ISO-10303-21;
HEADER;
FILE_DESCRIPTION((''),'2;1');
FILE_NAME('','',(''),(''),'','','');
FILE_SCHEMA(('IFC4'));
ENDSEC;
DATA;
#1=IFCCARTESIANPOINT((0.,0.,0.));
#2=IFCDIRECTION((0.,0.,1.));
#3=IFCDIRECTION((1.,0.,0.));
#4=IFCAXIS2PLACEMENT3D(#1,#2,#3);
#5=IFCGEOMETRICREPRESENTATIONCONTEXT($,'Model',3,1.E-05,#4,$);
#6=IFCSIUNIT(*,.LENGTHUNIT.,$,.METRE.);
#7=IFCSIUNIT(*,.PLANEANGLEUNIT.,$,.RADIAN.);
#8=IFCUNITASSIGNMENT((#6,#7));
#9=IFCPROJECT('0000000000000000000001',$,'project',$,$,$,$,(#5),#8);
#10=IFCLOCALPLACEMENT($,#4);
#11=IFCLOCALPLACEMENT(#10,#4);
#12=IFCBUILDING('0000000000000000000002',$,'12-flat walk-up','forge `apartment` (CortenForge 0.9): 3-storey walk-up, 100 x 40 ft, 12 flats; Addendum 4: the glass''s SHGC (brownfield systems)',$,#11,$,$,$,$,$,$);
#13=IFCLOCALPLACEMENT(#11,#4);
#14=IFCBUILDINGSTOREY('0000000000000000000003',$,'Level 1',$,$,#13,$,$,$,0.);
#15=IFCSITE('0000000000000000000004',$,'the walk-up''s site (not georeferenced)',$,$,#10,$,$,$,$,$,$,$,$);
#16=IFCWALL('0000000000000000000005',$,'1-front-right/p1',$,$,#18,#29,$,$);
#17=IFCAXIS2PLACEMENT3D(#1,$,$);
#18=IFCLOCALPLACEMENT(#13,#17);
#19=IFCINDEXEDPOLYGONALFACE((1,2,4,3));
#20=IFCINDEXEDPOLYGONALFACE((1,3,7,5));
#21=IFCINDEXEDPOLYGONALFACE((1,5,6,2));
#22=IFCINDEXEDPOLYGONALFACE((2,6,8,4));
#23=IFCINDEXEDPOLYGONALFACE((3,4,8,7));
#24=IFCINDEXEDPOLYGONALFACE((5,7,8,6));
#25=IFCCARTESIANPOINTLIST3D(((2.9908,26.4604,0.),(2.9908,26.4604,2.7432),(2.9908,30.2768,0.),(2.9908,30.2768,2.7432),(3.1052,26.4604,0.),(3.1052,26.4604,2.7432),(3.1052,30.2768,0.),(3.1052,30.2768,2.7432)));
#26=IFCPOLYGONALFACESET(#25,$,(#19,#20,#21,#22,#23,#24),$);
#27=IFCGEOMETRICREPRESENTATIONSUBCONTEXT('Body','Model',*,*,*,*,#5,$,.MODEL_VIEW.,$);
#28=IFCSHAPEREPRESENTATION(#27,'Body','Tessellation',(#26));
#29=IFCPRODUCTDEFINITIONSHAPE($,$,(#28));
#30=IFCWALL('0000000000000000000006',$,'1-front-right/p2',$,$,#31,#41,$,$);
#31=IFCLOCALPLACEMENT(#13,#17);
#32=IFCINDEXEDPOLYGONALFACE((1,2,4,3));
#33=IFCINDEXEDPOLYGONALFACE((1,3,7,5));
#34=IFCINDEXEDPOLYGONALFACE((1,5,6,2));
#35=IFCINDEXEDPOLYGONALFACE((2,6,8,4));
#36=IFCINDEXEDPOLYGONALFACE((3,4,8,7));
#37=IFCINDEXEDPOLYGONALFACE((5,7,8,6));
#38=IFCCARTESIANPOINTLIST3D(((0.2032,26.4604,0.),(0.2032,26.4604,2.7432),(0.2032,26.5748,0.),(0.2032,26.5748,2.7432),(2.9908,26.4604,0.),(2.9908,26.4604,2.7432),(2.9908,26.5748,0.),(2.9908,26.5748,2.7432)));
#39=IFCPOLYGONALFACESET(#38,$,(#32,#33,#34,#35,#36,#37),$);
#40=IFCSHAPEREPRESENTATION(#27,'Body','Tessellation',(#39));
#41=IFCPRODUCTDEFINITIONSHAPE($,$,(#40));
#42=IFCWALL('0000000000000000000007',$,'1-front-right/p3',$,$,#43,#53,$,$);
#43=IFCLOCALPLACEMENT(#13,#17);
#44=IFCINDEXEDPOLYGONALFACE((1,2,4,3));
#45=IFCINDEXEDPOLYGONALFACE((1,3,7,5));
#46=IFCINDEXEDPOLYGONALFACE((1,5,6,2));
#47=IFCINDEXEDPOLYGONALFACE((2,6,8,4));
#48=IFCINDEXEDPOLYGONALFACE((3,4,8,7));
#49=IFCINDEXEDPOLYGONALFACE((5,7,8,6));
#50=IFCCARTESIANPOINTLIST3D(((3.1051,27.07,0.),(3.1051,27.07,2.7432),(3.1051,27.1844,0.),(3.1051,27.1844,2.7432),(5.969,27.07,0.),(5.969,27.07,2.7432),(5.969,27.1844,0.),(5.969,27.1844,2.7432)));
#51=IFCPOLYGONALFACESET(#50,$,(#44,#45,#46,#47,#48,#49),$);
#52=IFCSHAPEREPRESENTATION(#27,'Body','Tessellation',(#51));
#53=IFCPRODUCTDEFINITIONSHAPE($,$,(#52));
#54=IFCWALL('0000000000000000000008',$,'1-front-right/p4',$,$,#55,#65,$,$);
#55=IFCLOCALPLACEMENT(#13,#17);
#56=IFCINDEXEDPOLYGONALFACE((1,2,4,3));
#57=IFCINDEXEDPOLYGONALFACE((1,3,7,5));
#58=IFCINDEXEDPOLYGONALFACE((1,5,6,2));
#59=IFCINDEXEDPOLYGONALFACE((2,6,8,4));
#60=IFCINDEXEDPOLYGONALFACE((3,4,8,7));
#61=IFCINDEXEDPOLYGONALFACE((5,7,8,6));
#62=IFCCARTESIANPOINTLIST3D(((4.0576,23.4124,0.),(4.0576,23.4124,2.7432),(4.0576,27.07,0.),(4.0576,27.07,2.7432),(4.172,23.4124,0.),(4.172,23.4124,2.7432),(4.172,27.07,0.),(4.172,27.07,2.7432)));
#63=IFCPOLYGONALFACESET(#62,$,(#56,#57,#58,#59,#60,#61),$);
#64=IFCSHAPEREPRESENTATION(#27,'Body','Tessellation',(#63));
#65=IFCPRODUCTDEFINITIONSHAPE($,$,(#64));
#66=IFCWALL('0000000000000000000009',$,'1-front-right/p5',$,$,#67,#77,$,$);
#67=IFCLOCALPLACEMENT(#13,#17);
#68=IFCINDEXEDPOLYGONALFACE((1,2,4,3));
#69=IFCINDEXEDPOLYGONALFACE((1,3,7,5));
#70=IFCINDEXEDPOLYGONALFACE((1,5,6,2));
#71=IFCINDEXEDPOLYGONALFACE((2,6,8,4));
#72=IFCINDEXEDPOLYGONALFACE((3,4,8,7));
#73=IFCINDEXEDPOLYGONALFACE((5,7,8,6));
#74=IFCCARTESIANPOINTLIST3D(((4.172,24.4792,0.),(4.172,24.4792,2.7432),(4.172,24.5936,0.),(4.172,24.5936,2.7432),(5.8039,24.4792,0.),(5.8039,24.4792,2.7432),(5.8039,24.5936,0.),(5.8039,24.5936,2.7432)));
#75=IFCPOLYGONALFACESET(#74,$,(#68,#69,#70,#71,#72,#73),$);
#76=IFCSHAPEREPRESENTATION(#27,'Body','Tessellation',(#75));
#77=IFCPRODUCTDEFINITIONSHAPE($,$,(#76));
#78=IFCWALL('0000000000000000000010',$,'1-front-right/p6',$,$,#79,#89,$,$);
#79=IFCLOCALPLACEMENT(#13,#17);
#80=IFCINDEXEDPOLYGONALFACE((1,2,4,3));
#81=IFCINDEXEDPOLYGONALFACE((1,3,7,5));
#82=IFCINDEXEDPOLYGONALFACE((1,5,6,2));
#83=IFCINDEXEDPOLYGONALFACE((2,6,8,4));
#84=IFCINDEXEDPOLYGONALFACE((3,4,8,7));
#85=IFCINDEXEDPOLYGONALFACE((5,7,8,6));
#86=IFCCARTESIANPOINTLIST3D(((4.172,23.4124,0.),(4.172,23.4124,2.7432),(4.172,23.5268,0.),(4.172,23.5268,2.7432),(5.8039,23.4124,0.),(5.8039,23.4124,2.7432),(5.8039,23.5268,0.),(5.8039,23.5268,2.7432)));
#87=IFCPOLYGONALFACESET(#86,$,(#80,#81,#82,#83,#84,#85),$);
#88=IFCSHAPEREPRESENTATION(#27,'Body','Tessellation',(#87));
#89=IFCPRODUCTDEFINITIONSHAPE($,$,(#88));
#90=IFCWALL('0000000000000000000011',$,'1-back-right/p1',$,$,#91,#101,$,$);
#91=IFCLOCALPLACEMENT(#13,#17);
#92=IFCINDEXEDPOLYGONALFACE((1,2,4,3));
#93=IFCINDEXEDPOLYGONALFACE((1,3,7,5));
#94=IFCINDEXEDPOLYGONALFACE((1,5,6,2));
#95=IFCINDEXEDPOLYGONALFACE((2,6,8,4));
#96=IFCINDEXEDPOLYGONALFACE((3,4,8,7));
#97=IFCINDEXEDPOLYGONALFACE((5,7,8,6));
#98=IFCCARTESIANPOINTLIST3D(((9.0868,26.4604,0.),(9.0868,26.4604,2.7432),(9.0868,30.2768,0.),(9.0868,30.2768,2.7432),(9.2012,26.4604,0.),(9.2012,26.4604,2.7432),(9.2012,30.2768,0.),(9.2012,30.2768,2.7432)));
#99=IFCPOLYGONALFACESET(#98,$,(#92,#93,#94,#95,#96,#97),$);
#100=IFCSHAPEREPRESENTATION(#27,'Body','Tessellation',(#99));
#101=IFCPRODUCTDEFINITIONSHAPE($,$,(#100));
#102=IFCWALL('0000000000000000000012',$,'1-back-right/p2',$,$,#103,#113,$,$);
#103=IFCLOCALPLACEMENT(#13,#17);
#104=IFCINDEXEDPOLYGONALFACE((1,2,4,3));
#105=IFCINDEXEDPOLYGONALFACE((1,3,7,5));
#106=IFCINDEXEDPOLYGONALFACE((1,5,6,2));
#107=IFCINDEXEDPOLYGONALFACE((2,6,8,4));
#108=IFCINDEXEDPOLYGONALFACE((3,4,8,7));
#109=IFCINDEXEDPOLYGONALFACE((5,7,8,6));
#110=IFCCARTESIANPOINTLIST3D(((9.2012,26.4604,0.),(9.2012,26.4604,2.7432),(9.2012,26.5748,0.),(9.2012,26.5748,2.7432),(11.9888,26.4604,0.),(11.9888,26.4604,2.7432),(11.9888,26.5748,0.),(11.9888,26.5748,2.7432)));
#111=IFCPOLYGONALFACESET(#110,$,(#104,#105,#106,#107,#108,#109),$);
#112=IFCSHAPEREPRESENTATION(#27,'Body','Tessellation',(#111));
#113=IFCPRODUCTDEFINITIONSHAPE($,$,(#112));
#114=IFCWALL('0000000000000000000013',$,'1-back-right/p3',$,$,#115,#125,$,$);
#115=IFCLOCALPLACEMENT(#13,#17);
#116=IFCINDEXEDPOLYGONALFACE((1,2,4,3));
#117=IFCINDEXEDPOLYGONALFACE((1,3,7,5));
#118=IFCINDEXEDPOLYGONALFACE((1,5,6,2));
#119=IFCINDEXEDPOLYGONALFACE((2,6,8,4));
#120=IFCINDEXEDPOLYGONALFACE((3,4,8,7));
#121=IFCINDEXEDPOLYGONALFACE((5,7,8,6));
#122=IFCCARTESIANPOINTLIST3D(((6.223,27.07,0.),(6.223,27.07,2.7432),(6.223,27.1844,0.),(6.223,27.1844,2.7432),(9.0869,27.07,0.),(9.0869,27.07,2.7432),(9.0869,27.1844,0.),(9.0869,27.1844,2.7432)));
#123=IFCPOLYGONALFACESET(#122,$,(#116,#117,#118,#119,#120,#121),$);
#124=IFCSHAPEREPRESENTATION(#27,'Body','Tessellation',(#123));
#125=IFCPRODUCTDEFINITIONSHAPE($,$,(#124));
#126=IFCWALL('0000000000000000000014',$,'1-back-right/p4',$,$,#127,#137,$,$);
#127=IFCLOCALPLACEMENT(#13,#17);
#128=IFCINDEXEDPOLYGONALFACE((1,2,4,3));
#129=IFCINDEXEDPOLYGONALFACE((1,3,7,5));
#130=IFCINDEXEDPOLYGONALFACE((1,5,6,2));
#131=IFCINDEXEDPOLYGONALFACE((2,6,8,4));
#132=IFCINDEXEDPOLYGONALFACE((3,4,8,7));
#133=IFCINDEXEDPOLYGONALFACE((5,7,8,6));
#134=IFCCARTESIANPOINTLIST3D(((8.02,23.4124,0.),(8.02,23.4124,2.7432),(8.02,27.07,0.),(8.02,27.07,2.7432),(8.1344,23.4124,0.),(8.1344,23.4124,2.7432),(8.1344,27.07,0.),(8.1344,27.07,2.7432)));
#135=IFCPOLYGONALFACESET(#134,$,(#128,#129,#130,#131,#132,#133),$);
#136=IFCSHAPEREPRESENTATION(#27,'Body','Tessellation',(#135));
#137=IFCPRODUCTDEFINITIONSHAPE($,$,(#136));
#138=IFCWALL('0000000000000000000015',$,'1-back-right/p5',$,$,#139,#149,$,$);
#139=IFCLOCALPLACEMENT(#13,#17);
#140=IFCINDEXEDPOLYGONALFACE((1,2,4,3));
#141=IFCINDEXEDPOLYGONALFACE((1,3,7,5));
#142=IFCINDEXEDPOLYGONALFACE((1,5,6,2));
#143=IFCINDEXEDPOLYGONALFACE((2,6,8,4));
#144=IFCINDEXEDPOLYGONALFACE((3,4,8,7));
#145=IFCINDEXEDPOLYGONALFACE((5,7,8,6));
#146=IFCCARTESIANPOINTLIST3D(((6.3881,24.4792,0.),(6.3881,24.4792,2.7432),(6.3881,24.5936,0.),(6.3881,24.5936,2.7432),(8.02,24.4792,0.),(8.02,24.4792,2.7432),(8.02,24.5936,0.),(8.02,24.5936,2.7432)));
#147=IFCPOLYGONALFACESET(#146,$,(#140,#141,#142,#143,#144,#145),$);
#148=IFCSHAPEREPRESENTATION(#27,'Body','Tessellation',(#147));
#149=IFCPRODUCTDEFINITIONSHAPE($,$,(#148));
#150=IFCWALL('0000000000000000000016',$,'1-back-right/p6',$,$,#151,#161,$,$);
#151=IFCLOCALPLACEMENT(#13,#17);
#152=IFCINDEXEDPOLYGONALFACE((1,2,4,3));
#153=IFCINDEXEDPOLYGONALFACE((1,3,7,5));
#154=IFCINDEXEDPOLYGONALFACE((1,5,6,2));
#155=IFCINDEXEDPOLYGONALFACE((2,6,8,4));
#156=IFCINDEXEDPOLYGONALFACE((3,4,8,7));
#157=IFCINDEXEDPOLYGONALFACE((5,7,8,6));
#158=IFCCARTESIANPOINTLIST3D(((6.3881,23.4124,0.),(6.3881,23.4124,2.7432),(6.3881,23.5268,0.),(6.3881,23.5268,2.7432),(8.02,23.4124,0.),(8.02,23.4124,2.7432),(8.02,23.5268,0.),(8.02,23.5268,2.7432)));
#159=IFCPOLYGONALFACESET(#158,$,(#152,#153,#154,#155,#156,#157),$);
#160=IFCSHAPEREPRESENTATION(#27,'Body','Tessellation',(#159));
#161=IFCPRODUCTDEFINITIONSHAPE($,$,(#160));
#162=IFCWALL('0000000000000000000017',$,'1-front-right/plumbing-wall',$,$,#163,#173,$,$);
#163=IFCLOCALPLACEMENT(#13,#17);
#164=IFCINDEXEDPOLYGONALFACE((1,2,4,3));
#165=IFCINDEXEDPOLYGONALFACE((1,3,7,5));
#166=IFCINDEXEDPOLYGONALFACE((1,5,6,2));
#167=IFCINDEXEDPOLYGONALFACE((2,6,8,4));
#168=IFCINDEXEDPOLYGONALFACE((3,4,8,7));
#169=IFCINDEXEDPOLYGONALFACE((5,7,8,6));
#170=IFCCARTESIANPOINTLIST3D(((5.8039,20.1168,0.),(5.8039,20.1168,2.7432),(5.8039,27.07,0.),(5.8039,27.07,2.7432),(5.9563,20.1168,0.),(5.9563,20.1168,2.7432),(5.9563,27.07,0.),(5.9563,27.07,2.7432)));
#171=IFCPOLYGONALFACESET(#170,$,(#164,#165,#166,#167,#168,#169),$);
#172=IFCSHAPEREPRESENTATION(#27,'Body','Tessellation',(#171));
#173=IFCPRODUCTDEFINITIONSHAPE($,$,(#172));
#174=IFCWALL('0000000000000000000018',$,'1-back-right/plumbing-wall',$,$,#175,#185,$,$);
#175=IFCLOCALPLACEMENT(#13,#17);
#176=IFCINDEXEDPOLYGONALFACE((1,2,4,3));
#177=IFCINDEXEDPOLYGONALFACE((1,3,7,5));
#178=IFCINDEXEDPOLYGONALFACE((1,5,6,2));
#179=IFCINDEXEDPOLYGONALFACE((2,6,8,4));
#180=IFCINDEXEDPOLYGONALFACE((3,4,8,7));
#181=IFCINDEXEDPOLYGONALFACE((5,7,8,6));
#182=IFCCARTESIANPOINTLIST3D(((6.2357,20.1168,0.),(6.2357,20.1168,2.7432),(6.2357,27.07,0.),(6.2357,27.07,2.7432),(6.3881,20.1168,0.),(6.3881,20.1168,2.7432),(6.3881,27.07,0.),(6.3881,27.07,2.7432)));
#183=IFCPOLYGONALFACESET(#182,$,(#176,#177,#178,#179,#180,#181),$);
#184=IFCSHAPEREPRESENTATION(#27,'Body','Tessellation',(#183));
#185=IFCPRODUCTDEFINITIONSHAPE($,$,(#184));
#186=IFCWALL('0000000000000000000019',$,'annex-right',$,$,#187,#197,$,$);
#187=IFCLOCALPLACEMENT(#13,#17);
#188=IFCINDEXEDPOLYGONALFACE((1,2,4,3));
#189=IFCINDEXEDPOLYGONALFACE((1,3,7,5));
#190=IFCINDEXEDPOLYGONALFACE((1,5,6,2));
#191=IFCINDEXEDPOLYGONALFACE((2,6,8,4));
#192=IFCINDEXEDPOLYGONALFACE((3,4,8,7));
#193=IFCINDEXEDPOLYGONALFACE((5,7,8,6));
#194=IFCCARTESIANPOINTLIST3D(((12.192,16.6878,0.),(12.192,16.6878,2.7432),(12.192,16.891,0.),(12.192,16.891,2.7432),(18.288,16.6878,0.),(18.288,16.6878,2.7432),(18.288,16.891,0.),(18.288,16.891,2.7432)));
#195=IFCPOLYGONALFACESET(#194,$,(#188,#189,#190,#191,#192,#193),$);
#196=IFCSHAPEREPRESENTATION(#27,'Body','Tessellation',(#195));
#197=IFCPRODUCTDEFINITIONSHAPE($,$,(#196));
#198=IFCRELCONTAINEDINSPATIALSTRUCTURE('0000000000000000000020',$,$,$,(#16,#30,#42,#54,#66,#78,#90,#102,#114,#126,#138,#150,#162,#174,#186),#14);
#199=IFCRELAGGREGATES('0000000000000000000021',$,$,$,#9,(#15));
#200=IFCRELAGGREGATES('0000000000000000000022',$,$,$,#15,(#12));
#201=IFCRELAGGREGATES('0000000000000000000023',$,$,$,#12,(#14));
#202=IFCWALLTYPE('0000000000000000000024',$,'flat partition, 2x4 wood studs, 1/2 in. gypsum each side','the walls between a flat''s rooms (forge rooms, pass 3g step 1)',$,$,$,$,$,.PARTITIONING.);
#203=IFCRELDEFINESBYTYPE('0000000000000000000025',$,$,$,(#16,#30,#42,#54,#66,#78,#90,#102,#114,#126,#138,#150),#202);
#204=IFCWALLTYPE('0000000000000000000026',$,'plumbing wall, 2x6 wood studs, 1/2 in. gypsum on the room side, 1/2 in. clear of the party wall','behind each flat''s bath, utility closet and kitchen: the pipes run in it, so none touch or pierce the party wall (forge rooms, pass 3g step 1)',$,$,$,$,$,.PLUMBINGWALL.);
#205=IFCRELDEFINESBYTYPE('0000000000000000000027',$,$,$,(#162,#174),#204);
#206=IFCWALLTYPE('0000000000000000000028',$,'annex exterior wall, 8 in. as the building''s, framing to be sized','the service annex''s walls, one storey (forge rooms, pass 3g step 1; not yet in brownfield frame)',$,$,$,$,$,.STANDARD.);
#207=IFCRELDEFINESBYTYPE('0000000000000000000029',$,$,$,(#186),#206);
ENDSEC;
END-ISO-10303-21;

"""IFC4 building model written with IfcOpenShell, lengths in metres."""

from ifc_helpers import new_model, si_unit, frame, frame_2d, origin, origin_with_axes, place, context, subcontext, project, spatial, rectangle, extrude, type_object, element, save


model = new_model("IFC4")

# Units and contexts
model_context = context("Model", 3, precision=1e-05, world=origin_with_axes())
body_context = subcontext(model_context, "Body", "Model", "MODEL_VIEW")
ifc_project = project(units=[si_unit("LENGTHUNIT", "METRE"), si_unit("PLANEANGLEUNIT", "RADIAN")], contexts=[model_context])

# Site, building, storey
site_placement = place(None, origin_with_axes())
site = spatial("IfcSite", under=ifc_project, at=site_placement, Name="the walk-up's site (not georeferenced)")
building_placement = place(site_placement, origin_with_axes())
building = spatial("IfcBuilding", under=site, at=building_placement, Name="12-flat walk-up", Description="forge `apartment` (CortenForge 0.9): 3-storey walk-up, 100 x 40 ft, 12 flats; Addendum 4: the glass's SHGC (brownfield systems)")
storey_placement = place(building_placement, origin_with_axes())
storey = spatial("IfcBuildingStorey", under=building, at=storey_placement, Name="Level 1", Elevation=0.0)

# Walls
wall_type_1 = type_object("IfcWallType", Name="flat partition, 2x4 wood studs, 1/2 in. gypsum each side", Description="the walls between a flat's rooms (forge rooms, pass 3g step 1)", PredefinedType="PARTITIONING")
wall_1_placement = place(storey_placement, frame((2.9909, 26.4605, 0.0), z_axis=(0.0, 0.0, 1.0), x_axis=(1.0, 0.0, 0.0)))
element("IfcWall", 1, at=wall_1_placement, inside=storey, type_object=wall_type_1, Name="1-front-right/p1", context=body_context, shape_type="SweptSolid", body=[
    extrude(rectangle(XDim=0.1143, YDim=3.8163, at=frame_2d((0.0572, 1.9082))), origin(), (0.0, 0.0, 1.0), 2.7432),
])
wall_2_placement = place(storey_placement, frame((0.2032, 26.4605, 0.0), z_axis=(0.0, 0.0, 1.0), x_axis=(1.0, 0.0, 0.0)))
element("IfcWall", 2, at=wall_2_placement, inside=storey, type_object=wall_type_1, Name="1-front-right/p2", context=body_context, shape_type="SweptSolid", body=[
    extrude(rectangle(XDim=2.7877, YDim=0.1143, at=frame_2d((1.3938, 0.0572))), origin(), (0.0, 0.0, 1.0), 2.7432),
])
wall_3_placement = place(storey_placement, frame((3.1051, 27.07, 0.0), z_axis=(0.0, 0.0, 1.0), x_axis=(1.0, 0.0, 0.0)))
element("IfcWall", 3, at=wall_3_placement, inside=storey, type_object=wall_type_1, Name="1-front-right/p3", context=body_context, shape_type="SweptSolid", body=[
    extrude(rectangle(XDim=2.8639, YDim=0.1143, at=frame_2d((1.4319, 0.0572))), origin(), (0.0, 0.0, 1.0), 2.7432),
])
wall_4_placement = place(storey_placement, frame((4.0576, 23.4124, 0.0), z_axis=(0.0, 0.0, 1.0), x_axis=(1.0, 0.0, 0.0)))
element("IfcWall", 4, at=wall_4_placement, inside=storey, type_object=wall_type_1, Name="1-front-right/p4", context=body_context, shape_type="SweptSolid", body=[
    extrude(rectangle(XDim=0.1143, YDim=3.6576, at=frame_2d((0.0572, 1.8288))), origin(), (0.0, 0.0, 1.0), 2.7432),
])
for number, where, z_axis, x_axis, name in (
    (5, (4.1719, 24.4793, 0.0), (0.0, 0.0, 1.0), (1.0, 0.0, 0.0), "1-front-right/p5"),
    (6, (4.1719, 23.4124, 0.0), (0.0, 0.0, 1.0), (1.0, 0.0, 0.0), "1-front-right/p6"),
):
    element("IfcWall", number, at=place(storey_placement, frame(where, z_axis=z_axis, x_axis=x_axis)), inside=storey, type_object=wall_type_1, Name=name, context=body_context, shape_type="SweptSolid", body=[
        extrude(rectangle(XDim=1.6319, YDim=0.1143, at=frame_2d((0.816, 0.0572))), origin(), (0.0, 0.0, 1.0), 2.7432),
    ])
wall_5_placement = place(storey_placement, frame((9.0869, 26.4605, 0.0), z_axis=(0.0, 0.0, 1.0), x_axis=(1.0, 0.0, 0.0)))
element("IfcWall", 7, at=wall_5_placement, inside=storey, type_object=wall_type_1, Name="1-back-right/p1", context=body_context, shape_type="SweptSolid", body=[
    extrude(rectangle(XDim=0.1143, YDim=3.8163, at=frame_2d((0.0572, 1.9082))), origin(), (0.0, 0.0, 1.0), 2.7432),
])
wall_6_placement = place(storey_placement, frame((9.2012, 26.4605, 0.0), z_axis=(0.0, 0.0, 1.0), x_axis=(1.0, 0.0, 0.0)))
element("IfcWall", 8, at=wall_6_placement, inside=storey, type_object=wall_type_1, Name="1-back-right/p2", context=body_context, shape_type="SweptSolid", body=[
    extrude(rectangle(XDim=2.7876, YDim=0.1143, at=frame_2d((1.3938, 0.0572))), origin(), (0.0, 0.0, 1.0), 2.7432),
])
wall_7_placement = place(storey_placement, frame((6.223, 27.07, 0.0), z_axis=(0.0, 0.0, 1.0), x_axis=(1.0, 0.0, 0.0)))
element("IfcWall", 9, at=wall_7_placement, inside=storey, type_object=wall_type_1, Name="1-back-right/p3", context=body_context, shape_type="SweptSolid", body=[
    extrude(rectangle(XDim=2.8639, YDim=0.1143, at=frame_2d((1.4319, 0.0572))), origin(), (0.0, 0.0, 1.0), 2.7432),
])
wall_8_placement = place(storey_placement, frame((8.02, 23.4124, 0.0), z_axis=(0.0, 0.0, 1.0), x_axis=(1.0, 0.0, 0.0)))
element("IfcWall", 10, at=wall_8_placement, inside=storey, type_object=wall_type_1, Name="1-back-right/p4", context=body_context, shape_type="SweptSolid", body=[
    extrude(rectangle(XDim=0.1143, YDim=3.6576, at=frame_2d((0.0572, 1.8288))), origin(), (0.0, 0.0, 1.0), 2.7432),
])
for number, where, z_axis, x_axis, name in (
    (11, (6.3881, 24.4793, 0.0), (0.0, 0.0, 1.0), (1.0, 0.0, 0.0), "1-back-right/p5"),
    (12, (6.3881, 23.4124, 0.0), (0.0, 0.0, 1.0), (1.0, 0.0, 0.0), "1-back-right/p6"),
):
    element("IfcWall", number, at=place(storey_placement, frame(where, z_axis=z_axis, x_axis=x_axis)), inside=storey, type_object=wall_type_1, Name=name, context=body_context, shape_type="SweptSolid", body=[
        extrude(rectangle(XDim=1.6319, YDim=0.1143, at=frame_2d((0.816, 0.0572))), origin(), (0.0, 0.0, 1.0), 2.7432),
    ])
wall_type_2 = type_object("IfcWallType", Name="plumbing wall, 2x6 wood studs, 1/2 in. gypsum on the room side, 1/2 in. clear of the party wall", Description="behind each flat's bath, utility closet and kitchen: the pipes run in it, so none touch or pierce the party wall (forge rooms, pass 3g step 1)", PredefinedType="PLUMBINGWALL")
for number, where, z_axis, x_axis, name in (
    (13, (5.8039, 20.1168, 0.0), (0.0, 0.0, 1.0), (1.0, 0.0, 0.0), "1-front-right/plumbing-wall"),
    (14, (6.2357, 20.1168, 0.0), (0.0, 0.0, 1.0), (1.0, 0.0, 0.0), "1-back-right/plumbing-wall"),
):
    element("IfcWall", number, at=place(storey_placement, frame(where, z_axis=z_axis, x_axis=x_axis)), inside=storey, type_object=wall_type_2, Name=name, context=body_context, shape_type="SweptSolid", body=[
        extrude(rectangle(XDim=0.1524, YDim=6.9532, at=frame_2d((0.0762, 3.4766))), origin(), (0.0, 0.0, 1.0), 2.7432),
    ])
wall_type_3 = type_object("IfcWallType", Name="annex exterior wall, 8 in. as the building's, framing to be sized", Description="the service annex's walls, one storey (forge rooms, pass 3g step 1; not yet in brownfield frame)", PredefinedType="STANDARD")
wall_9_placement = place(storey_placement, frame((12.192, 16.6878, 0.0), z_axis=(0.0, 0.0, 1.0), x_axis=(1.0, 0.0, 0.0)))
element("IfcWall", 15, at=wall_9_placement, inside=storey, type_object=wall_type_3, Name="annex-right", context=body_context, shape_type="SweptSolid", body=[
    extrude(rectangle(XDim=6.096, YDim=0.2032, at=frame_2d((3.048, 0.1016))), origin(), (0.0, 0.0, 1.0), 2.7432),
])

save(model, "model.ifc")
